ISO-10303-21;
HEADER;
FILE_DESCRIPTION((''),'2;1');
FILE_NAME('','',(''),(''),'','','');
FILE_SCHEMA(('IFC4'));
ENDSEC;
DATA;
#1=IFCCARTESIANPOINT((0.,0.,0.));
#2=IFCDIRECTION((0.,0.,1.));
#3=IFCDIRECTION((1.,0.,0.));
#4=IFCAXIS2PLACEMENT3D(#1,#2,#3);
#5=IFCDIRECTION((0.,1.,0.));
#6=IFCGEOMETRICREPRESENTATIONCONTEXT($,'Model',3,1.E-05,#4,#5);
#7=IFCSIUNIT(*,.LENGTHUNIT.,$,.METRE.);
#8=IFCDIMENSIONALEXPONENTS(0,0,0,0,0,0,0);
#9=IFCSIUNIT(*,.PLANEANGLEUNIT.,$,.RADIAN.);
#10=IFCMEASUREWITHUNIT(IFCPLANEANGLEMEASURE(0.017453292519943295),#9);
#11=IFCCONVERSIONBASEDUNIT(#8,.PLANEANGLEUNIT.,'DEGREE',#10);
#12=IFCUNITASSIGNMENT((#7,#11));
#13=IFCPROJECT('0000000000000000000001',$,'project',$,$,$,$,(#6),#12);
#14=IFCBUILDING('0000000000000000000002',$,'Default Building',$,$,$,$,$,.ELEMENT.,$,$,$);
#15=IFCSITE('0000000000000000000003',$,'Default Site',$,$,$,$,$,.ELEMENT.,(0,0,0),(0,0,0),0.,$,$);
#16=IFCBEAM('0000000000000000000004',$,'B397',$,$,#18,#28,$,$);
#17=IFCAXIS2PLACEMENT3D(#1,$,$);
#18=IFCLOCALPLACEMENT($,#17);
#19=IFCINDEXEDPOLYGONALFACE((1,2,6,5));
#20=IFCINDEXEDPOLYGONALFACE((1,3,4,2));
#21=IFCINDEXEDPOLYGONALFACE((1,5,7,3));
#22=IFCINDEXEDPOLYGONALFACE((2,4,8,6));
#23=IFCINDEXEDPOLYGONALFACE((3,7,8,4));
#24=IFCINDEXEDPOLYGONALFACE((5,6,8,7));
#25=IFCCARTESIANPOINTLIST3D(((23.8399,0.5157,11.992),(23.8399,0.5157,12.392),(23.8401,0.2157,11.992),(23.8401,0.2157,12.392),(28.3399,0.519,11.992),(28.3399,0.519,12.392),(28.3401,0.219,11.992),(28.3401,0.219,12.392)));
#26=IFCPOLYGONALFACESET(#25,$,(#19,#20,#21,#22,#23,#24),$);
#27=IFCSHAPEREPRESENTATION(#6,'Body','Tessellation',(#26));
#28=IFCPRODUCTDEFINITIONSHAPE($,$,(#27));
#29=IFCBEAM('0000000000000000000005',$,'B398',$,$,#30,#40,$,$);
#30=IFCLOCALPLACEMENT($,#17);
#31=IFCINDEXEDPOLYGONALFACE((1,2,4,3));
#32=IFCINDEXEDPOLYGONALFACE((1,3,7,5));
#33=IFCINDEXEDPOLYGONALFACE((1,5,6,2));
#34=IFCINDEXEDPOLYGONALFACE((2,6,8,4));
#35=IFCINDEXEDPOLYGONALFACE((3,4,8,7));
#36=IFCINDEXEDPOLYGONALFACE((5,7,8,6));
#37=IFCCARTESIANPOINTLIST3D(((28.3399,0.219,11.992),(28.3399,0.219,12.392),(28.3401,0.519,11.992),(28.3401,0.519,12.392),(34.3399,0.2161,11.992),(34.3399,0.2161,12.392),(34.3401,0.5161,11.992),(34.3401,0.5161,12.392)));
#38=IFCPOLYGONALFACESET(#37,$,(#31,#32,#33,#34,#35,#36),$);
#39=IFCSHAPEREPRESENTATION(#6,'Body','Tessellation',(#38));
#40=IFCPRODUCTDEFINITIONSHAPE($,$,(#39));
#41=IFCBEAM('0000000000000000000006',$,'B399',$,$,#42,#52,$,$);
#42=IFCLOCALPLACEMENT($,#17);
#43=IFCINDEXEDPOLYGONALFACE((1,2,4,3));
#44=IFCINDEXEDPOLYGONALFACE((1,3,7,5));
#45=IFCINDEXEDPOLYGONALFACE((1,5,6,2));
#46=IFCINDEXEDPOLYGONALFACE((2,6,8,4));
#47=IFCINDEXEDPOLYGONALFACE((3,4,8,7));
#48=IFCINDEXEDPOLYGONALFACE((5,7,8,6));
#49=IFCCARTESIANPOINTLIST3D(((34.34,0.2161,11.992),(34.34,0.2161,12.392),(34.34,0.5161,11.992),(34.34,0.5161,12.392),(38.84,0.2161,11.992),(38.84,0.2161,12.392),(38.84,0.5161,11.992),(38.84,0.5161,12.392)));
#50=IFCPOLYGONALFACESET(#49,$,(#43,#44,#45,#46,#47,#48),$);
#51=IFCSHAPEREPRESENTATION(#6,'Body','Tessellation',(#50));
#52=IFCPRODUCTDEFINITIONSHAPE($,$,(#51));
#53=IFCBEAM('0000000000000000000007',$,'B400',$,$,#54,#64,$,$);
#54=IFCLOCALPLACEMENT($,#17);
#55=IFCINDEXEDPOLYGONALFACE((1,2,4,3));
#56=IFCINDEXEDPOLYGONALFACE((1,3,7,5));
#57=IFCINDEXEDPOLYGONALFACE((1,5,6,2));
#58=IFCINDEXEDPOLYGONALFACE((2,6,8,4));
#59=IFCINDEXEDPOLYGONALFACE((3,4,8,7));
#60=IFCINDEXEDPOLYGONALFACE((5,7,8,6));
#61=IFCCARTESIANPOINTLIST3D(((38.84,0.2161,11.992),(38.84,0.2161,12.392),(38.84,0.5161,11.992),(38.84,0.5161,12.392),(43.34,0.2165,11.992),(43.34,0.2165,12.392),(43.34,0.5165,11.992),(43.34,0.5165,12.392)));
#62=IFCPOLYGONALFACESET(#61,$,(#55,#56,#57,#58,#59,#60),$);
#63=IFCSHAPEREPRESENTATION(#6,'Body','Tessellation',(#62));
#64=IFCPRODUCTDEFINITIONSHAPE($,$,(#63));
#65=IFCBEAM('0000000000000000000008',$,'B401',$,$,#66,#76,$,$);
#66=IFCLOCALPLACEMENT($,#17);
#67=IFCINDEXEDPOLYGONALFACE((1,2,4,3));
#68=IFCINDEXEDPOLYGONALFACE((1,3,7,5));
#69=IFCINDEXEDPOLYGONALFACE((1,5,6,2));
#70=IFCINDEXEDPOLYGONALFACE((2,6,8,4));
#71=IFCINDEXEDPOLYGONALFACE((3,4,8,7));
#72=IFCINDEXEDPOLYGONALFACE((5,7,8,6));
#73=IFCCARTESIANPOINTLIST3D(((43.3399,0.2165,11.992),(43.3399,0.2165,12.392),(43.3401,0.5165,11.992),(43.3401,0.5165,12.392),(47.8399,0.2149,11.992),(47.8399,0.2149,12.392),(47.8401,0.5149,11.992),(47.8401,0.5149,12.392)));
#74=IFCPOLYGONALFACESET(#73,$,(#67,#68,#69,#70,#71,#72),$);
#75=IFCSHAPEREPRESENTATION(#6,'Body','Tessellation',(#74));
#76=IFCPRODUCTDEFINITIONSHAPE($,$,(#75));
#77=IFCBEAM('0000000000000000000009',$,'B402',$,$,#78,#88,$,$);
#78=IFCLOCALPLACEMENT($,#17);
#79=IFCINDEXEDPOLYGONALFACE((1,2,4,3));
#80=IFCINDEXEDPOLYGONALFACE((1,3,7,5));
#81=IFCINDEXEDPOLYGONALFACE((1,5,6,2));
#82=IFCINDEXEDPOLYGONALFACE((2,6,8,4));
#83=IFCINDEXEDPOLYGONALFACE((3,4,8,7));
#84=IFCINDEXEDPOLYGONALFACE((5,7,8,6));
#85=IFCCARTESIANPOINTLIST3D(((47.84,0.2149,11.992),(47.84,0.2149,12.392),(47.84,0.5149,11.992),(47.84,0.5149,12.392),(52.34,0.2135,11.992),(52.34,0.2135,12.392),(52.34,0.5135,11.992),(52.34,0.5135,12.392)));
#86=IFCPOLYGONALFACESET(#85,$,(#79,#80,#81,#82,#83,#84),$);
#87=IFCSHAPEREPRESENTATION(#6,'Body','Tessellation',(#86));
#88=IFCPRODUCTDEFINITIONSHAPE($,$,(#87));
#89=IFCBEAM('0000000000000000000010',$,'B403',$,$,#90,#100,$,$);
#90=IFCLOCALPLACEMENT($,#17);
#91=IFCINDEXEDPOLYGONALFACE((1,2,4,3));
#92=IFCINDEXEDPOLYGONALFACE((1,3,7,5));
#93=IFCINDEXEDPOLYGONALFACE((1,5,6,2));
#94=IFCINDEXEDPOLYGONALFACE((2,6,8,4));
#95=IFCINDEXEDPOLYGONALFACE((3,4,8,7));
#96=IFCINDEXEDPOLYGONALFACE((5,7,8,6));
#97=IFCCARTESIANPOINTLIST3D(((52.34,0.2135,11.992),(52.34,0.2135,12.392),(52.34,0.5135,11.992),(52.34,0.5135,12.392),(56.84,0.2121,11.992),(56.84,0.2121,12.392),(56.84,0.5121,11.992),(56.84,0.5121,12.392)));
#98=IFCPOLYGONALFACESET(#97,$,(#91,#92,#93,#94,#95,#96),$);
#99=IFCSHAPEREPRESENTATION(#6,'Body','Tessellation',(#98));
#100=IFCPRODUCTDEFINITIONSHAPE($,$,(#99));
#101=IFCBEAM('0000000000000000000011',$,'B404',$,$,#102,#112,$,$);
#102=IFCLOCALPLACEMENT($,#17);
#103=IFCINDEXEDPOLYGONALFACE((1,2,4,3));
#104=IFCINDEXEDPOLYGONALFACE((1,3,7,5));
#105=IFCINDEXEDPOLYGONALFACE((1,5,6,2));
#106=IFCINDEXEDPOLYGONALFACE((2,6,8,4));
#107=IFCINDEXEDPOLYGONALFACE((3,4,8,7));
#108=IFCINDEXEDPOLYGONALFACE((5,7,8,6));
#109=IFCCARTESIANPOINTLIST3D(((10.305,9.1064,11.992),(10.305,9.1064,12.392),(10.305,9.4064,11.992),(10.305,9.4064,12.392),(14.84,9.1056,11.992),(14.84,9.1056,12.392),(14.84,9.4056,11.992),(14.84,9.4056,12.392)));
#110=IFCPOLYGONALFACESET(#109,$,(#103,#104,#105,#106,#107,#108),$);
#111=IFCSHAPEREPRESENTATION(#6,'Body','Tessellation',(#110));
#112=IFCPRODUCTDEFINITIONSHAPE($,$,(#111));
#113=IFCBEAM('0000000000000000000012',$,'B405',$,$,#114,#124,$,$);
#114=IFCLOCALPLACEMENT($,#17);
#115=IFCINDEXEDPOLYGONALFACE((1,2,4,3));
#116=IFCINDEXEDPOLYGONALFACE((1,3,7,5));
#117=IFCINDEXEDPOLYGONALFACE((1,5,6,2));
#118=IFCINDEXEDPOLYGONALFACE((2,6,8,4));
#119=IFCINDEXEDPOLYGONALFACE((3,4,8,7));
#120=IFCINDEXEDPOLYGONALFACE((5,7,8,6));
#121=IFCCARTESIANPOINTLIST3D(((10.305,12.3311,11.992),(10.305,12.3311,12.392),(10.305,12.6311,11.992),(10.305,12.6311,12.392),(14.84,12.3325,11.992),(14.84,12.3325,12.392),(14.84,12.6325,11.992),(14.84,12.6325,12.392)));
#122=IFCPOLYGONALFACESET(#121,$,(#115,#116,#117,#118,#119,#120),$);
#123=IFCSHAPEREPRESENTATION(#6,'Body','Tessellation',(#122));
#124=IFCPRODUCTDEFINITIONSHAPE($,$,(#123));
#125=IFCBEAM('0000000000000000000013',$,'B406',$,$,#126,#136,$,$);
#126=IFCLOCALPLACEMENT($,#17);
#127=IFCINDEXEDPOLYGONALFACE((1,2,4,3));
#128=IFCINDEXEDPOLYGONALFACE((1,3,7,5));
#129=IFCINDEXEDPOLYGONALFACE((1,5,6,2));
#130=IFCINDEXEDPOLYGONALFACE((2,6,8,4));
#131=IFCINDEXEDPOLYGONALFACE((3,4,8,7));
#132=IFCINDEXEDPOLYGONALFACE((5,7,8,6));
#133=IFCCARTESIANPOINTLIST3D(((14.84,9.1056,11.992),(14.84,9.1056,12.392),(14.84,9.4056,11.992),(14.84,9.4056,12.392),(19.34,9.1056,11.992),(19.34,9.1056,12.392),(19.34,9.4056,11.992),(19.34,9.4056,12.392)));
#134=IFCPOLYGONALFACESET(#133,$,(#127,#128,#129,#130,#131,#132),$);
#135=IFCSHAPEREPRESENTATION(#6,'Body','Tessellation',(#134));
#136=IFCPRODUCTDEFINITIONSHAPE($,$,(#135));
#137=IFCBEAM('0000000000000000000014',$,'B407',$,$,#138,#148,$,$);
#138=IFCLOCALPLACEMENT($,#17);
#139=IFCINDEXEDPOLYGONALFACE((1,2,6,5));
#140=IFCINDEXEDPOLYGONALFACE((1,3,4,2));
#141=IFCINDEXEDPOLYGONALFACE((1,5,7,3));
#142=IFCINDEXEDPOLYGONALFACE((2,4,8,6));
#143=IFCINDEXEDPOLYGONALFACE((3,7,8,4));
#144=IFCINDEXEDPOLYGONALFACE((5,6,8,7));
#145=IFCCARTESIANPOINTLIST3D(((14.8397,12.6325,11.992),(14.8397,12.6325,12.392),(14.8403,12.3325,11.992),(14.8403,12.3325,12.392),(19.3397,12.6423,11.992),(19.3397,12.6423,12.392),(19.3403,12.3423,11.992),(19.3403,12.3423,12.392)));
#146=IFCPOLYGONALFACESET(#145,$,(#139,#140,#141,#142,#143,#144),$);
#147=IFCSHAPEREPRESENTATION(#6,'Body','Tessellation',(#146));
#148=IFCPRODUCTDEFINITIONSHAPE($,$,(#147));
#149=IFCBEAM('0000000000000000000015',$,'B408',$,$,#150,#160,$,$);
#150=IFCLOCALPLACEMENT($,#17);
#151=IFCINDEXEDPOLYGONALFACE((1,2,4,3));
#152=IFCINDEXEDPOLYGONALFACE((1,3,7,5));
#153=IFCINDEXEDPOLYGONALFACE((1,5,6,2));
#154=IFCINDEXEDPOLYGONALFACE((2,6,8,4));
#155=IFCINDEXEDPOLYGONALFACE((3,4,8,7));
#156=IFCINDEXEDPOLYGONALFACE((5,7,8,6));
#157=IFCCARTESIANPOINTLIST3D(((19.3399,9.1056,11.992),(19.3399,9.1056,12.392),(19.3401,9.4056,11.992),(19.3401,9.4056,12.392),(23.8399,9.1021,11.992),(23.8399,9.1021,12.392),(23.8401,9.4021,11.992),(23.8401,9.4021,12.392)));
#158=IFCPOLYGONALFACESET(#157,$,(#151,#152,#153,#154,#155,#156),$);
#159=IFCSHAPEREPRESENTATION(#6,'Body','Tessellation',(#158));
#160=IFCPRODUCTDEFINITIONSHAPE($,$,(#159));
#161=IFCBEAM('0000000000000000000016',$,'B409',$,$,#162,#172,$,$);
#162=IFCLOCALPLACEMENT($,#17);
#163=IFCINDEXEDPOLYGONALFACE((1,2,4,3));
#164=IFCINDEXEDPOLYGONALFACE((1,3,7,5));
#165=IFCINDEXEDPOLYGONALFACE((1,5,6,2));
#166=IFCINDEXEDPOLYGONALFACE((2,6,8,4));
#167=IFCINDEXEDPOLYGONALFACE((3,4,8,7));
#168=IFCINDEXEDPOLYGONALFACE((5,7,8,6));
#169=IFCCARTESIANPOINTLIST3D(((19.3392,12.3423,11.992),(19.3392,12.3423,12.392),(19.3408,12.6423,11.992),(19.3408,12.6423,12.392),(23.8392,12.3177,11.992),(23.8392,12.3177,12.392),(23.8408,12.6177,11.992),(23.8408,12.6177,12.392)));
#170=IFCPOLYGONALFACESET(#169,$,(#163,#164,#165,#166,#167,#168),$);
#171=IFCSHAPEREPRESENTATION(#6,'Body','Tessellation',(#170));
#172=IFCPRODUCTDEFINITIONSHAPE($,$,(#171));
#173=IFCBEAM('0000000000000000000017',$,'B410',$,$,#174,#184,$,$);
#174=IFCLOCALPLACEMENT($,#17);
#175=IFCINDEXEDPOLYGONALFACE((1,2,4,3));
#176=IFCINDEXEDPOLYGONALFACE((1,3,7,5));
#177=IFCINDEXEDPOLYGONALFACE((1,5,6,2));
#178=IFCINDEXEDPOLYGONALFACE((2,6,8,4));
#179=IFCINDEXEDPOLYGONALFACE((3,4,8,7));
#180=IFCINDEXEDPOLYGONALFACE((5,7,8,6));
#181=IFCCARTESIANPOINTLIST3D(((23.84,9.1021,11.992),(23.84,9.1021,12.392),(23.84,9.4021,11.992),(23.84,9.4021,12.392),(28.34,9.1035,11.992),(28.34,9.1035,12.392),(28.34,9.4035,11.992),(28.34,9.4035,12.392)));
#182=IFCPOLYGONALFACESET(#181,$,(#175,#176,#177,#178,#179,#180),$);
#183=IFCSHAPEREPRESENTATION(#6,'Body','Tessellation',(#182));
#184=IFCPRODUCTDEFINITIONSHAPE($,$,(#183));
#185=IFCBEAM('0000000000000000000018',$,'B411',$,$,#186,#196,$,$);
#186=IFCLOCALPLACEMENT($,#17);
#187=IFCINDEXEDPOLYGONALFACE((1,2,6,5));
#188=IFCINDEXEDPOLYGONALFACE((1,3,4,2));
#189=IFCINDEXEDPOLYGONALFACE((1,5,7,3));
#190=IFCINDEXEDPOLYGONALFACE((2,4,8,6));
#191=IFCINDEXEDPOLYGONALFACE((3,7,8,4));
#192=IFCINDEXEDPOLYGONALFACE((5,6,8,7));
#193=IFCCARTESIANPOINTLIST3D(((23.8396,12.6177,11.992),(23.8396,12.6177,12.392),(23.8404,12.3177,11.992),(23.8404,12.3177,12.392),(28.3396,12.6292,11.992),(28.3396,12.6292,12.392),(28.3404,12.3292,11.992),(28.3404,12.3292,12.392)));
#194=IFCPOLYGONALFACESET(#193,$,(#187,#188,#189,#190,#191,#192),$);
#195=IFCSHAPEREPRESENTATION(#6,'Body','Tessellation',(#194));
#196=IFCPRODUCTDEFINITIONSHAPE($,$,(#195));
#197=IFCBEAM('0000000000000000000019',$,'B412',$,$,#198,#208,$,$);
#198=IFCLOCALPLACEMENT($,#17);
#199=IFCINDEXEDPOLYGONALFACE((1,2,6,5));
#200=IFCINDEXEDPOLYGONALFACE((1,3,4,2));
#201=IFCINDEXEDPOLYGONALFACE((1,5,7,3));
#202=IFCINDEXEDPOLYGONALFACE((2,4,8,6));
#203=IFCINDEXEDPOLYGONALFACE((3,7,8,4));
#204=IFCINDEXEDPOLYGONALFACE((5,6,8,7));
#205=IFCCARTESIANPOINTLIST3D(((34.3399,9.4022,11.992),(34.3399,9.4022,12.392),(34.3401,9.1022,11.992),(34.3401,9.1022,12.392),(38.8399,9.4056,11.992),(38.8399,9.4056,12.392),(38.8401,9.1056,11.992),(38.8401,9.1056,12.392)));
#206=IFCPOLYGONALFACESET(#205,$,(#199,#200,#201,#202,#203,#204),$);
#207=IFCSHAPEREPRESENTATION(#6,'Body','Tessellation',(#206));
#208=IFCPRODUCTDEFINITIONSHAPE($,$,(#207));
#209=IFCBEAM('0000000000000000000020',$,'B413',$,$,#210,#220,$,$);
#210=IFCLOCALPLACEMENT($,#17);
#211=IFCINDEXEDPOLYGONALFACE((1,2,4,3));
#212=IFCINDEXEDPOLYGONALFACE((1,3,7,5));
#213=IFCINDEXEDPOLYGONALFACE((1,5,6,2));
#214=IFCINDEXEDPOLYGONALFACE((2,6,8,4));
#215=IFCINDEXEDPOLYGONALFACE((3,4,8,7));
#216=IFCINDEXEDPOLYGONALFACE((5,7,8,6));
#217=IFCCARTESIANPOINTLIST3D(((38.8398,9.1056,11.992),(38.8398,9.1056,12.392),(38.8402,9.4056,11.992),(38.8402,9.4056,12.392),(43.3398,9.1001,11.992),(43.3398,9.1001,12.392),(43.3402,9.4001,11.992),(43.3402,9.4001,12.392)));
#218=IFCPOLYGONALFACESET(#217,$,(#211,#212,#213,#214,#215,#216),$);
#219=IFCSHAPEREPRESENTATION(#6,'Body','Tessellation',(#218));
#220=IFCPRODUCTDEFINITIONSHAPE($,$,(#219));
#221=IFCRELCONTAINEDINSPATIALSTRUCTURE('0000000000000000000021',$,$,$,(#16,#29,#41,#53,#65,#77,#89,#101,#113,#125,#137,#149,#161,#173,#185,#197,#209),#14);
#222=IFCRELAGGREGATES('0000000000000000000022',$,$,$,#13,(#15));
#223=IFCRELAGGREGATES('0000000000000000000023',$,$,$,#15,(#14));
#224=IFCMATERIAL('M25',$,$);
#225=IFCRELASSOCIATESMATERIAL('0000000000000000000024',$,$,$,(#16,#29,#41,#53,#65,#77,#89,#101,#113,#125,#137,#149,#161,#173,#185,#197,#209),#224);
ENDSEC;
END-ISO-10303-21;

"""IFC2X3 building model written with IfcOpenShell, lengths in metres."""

from ifc_helpers import new_model, entity, si_unit, converted_unit, direction, frame, frame_2d, origin_with_axes, place, context, project, spatial, rectangle, extrude, material, element, save


model = new_model("IFC2X3")

# Units and contexts
model_context = context("Model", 3, precision=1e-05, world=origin_with_axes(), true_north=direction((0.0, 1.0, 0.0)))
ifc_project = project(units=[si_unit("LENGTHUNIT", "METRE"), converted_unit("PLANEANGLEUNIT", "DEGREE", entity("IfcPlaneAngleMeasure", 0.017453292519943295), si_unit("PLANEANGLEUNIT", "RADIAN"), dimensions=[0, 0, 0, 0, 0, 0, 0])], contexts=[model_context])

# Site, building
site = spatial("IfcSite", under=ifc_project, Name="Default Site", CompositionType="ELEMENT", RefLatitude=(0, 0, 0), RefLongitude=(0, 0, 0), RefElevation=0.0)
building = spatial("IfcBuilding", under=site, Name="Default Building", CompositionType="ELEMENT")

# Beams
ifc_material = material(Name="M25")
placement = place(None, origin_with_axes())
element("IfcBeam", 1, at=placement, inside=building, material=ifc_material, Name="B397", context=model_context, shape_type="SweptSolid", body=[
    extrude(rectangle(XDim=0.3, YDim=0.4, at=frame_2d((0.0, 0.0), x_axis=(0.0, 1.0, 0.0))), frame((23.84, 0.3657, 12.192), z_axis=(1.0, 0.00075, 0.0), x_axis=(0.0, 0.0, -1.0)), (0.0, 0.0, 1.0), 4.5),
])
element("IfcBeam", 2, at=placement, inside=building, material=ifc_material, Name="B398", context=model_context, shape_type="SweptSolid", body=[
    extrude(rectangle(XDim=0.3, YDim=0.4, at=frame_2d((0.0, 0.0), x_axis=(0.0, 1.0, 0.0))), frame((28.34, 0.369, 12.192), z_axis=(1.0, -0.000487, 0.0), x_axis=(0.0, 0.0, -1.0)), (0.0, 0.0, 1.0), 6.0),
])
element("IfcBeam", 3, at=placement, inside=building, material=ifc_material, Name="B399", context=model_context, shape_type="SweptSolid", body=[
    extrude(rectangle(XDim=0.3, YDim=0.4, at=frame_2d((0.0, 0.0), x_axis=(0.0, 1.0, 0.0))), frame((34.34, 0.3661, 12.192), z_axis=(1.0, 0.000003, 0.0), x_axis=(0.0, 0.0, -1.0)), (0.0, 0.0, 1.0), 4.5),
])
element("IfcBeam", 4, at=placement, inside=building, material=ifc_material, Name="B400", context=model_context, shape_type="SweptSolid", body=[
    extrude(rectangle(XDim=0.3, YDim=0.4, at=frame_2d((0.0, 0.0), x_axis=(0.0, 1.0, 0.0))), frame((38.84, 0.3661, 12.192), z_axis=(1.0, 0.000077, 0.0), x_axis=(0.0, 0.0, -1.0)), (0.0, 0.0, 1.0), 4.5),
])
element("IfcBeam", 5, at=placement, inside=building, material=ifc_material, Name="B401", context=model_context, shape_type="SweptSolid", body=[
    extrude(rectangle(XDim=0.3, YDim=0.4, at=frame_2d((0.0, 0.0), x_axis=(0.0, 1.0, 0.0))), frame((43.34, 0.3665, 12.192), z_axis=(1.0, -0.000358, 0.0), x_axis=(0.0, 0.0, -1.0)), (0.0, 0.0, 1.0), 4.5),
])
element("IfcBeam", 6, at=placement, inside=building, material=ifc_material, Name="B402", context=model_context, shape_type="SweptSolid", body=[
    extrude(rectangle(XDim=0.3, YDim=0.4, at=frame_2d((0.0, 0.0), x_axis=(0.0, 1.0, 0.0))), frame((47.84, 0.3649, 12.192), z_axis=(1.0, -0.000297, 0.0), x_axis=(0.0, 0.0, -1.0)), (0.0, 0.0, 1.0), 4.5),
])
element("IfcBeam", 7, at=placement, inside=building, material=ifc_material, Name="B403", context=model_context, shape_type="SweptSolid", body=[
    extrude(rectangle(XDim=0.3, YDim=0.4, at=frame_2d((0.0, 0.0), x_axis=(0.0, 1.0, 0.0))), frame((52.34, 0.3635, 12.192), z_axis=(1.0, -0.000311, 0.0), x_axis=(0.0, 0.0, -1.0)), (0.0, 0.0, 1.0), 4.5),
])
element("IfcBeam", 8, at=placement, inside=building, material=ifc_material, Name="B404", context=model_context, shape_type="SweptSolid", body=[
    extrude(rectangle(XDim=0.3, YDim=0.4, at=frame_2d((0.0, 0.0), x_axis=(0.0, 1.0, 0.0))), frame((10.305, 9.2564, 12.192), z_axis=(1.0, -0.000182, 0.0), x_axis=(0.0, 0.0, -1.0)), (0.0, 0.0, 1.0), 4.535),
])
element("IfcBeam", 9, at=placement, inside=building, material=ifc_material, Name="B405", context=model_context, shape_type="SweptSolid", body=[
    extrude(rectangle(XDim=0.3, YDim=0.4, at=frame_2d((0.0, 0.0), x_axis=(0.0, 1.0, 0.0))), frame((10.305, 12.4811, 12.192), z_axis=(1.0, 0.000301, 0.0), x_axis=(0.0, 0.0, -1.0)), (0.0, 0.0, 1.0), 4.535),
])
element("IfcBeam", 10, at=placement, inside=building, material=ifc_material, Name="B406", context=model_context, shape_type="SweptSolid", body=[
    extrude(rectangle(XDim=0.3, YDim=0.4, at=frame_2d((0.0, 0.0), x_axis=(0.0, 1.0, 0.0))), frame((14.84, 9.2556, 12.192), z_axis=(1.0, 0.000013, 0.0), x_axis=(0.0, 0.0, -1.0)), (0.0, 0.0, 1.0), 4.5),
])
element("IfcBeam", 11, at=placement, inside=building, material=ifc_material, Name="B407", context=model_context, shape_type="SweptSolid", body=[
    extrude(rectangle(XDim=0.3, YDim=0.4, at=frame_2d((0.0, 0.0), x_axis=(0.0, 1.0, 0.0))), frame((14.84, 12.4825, 12.192), z_axis=(0.999998, 0.002176, 0.0), x_axis=(0.0, 0.0, -1.0)), (0.0, 0.0, 1.0), 4.5),
])
element("IfcBeam", 12, at=placement, inside=building, material=ifc_material, Name="B408", context=model_context, shape_type="SweptSolid", body=[
    extrude(rectangle(XDim=0.3, YDim=0.4, at=frame_2d((0.0, 0.0), x_axis=(0.0, 1.0, 0.0))), frame((19.34, 9.2556, 12.192), z_axis=(1.0, -0.000779, 0.0), x_axis=(0.0, 0.0, -1.0)), (0.0, 0.0, 1.0), 4.5),
])
element("IfcBeam", 13, at=placement, inside=building, material=ifc_material, Name="B409", context=model_context, shape_type="SweptSolid", body=[
    extrude(rectangle(XDim=0.3, YDim=0.4, at=frame_2d((0.0, 0.0), x_axis=(0.0, 1.0, 0.0))), frame((19.34, 12.4923, 12.192), z_axis=(0.999985, -0.005463, 0.0), x_axis=(0.0, 0.0, -1.0)), (0.0, 0.0, 1.0), 4.5001),
])
element("IfcBeam", 14, at=placement, inside=building, material=ifc_material, Name="B410", context=model_context, shape_type="SweptSolid", body=[
    extrude(rectangle(XDim=0.3, YDim=0.4, at=frame_2d((0.0, 0.0), x_axis=(0.0, 1.0, 0.0))), frame((23.84, 9.2521, 12.192), z_axis=(1.0, 0.000307, 0.0), x_axis=(0.0, 0.0, -1.0)), (0.0, 0.0, 1.0), 4.5),
])
element("IfcBeam", 15, at=placement, inside=building, material=ifc_material, Name="B411", context=model_context, shape_type="SweptSolid", body=[
    extrude(rectangle(XDim=0.3, YDim=0.4, at=frame_2d((0.0, 0.0), x_axis=(0.0, 1.0, 0.0))), frame((23.84, 12.4677, 12.192), z_axis=(0.999997, 0.002551, 0.0), x_axis=(0.0, 0.0, -1.0)), (0.0, 0.0, 1.0), 4.5),
])
element("IfcBeam", 16, at=placement, inside=building, material=ifc_material, Name="B412", context=model_context, shape_type="SweptSolid", body=[
    extrude(rectangle(XDim=0.3, YDim=0.4, at=frame_2d((0.0, 0.0), x_axis=(0.0, 1.0, 0.0))), frame((34.34, 9.2522, 12.192), z_axis=(1.0, 0.000748, 0.0), x_axis=(0.0, 0.0, -1.0)), (0.0, 0.0, 1.0), 4.5),
])
element("IfcBeam", 17, at=placement, inside=building, material=ifc_material, Name="B413", context=model_context, shape_type="SweptSolid", body=[
    extrude(rectangle(XDim=0.3, YDim=0.4, at=frame_2d((0.0, 0.0), x_axis=(0.0, 1.0, 0.0))), frame((38.84, 9.2556, 12.192), z_axis=(0.999999, -0.001227, 0.0), x_axis=(0.0, 0.0, -1.0)), (0.0, 0.0, 1.0), 4.5),
])

save(model, "model.ifc")
